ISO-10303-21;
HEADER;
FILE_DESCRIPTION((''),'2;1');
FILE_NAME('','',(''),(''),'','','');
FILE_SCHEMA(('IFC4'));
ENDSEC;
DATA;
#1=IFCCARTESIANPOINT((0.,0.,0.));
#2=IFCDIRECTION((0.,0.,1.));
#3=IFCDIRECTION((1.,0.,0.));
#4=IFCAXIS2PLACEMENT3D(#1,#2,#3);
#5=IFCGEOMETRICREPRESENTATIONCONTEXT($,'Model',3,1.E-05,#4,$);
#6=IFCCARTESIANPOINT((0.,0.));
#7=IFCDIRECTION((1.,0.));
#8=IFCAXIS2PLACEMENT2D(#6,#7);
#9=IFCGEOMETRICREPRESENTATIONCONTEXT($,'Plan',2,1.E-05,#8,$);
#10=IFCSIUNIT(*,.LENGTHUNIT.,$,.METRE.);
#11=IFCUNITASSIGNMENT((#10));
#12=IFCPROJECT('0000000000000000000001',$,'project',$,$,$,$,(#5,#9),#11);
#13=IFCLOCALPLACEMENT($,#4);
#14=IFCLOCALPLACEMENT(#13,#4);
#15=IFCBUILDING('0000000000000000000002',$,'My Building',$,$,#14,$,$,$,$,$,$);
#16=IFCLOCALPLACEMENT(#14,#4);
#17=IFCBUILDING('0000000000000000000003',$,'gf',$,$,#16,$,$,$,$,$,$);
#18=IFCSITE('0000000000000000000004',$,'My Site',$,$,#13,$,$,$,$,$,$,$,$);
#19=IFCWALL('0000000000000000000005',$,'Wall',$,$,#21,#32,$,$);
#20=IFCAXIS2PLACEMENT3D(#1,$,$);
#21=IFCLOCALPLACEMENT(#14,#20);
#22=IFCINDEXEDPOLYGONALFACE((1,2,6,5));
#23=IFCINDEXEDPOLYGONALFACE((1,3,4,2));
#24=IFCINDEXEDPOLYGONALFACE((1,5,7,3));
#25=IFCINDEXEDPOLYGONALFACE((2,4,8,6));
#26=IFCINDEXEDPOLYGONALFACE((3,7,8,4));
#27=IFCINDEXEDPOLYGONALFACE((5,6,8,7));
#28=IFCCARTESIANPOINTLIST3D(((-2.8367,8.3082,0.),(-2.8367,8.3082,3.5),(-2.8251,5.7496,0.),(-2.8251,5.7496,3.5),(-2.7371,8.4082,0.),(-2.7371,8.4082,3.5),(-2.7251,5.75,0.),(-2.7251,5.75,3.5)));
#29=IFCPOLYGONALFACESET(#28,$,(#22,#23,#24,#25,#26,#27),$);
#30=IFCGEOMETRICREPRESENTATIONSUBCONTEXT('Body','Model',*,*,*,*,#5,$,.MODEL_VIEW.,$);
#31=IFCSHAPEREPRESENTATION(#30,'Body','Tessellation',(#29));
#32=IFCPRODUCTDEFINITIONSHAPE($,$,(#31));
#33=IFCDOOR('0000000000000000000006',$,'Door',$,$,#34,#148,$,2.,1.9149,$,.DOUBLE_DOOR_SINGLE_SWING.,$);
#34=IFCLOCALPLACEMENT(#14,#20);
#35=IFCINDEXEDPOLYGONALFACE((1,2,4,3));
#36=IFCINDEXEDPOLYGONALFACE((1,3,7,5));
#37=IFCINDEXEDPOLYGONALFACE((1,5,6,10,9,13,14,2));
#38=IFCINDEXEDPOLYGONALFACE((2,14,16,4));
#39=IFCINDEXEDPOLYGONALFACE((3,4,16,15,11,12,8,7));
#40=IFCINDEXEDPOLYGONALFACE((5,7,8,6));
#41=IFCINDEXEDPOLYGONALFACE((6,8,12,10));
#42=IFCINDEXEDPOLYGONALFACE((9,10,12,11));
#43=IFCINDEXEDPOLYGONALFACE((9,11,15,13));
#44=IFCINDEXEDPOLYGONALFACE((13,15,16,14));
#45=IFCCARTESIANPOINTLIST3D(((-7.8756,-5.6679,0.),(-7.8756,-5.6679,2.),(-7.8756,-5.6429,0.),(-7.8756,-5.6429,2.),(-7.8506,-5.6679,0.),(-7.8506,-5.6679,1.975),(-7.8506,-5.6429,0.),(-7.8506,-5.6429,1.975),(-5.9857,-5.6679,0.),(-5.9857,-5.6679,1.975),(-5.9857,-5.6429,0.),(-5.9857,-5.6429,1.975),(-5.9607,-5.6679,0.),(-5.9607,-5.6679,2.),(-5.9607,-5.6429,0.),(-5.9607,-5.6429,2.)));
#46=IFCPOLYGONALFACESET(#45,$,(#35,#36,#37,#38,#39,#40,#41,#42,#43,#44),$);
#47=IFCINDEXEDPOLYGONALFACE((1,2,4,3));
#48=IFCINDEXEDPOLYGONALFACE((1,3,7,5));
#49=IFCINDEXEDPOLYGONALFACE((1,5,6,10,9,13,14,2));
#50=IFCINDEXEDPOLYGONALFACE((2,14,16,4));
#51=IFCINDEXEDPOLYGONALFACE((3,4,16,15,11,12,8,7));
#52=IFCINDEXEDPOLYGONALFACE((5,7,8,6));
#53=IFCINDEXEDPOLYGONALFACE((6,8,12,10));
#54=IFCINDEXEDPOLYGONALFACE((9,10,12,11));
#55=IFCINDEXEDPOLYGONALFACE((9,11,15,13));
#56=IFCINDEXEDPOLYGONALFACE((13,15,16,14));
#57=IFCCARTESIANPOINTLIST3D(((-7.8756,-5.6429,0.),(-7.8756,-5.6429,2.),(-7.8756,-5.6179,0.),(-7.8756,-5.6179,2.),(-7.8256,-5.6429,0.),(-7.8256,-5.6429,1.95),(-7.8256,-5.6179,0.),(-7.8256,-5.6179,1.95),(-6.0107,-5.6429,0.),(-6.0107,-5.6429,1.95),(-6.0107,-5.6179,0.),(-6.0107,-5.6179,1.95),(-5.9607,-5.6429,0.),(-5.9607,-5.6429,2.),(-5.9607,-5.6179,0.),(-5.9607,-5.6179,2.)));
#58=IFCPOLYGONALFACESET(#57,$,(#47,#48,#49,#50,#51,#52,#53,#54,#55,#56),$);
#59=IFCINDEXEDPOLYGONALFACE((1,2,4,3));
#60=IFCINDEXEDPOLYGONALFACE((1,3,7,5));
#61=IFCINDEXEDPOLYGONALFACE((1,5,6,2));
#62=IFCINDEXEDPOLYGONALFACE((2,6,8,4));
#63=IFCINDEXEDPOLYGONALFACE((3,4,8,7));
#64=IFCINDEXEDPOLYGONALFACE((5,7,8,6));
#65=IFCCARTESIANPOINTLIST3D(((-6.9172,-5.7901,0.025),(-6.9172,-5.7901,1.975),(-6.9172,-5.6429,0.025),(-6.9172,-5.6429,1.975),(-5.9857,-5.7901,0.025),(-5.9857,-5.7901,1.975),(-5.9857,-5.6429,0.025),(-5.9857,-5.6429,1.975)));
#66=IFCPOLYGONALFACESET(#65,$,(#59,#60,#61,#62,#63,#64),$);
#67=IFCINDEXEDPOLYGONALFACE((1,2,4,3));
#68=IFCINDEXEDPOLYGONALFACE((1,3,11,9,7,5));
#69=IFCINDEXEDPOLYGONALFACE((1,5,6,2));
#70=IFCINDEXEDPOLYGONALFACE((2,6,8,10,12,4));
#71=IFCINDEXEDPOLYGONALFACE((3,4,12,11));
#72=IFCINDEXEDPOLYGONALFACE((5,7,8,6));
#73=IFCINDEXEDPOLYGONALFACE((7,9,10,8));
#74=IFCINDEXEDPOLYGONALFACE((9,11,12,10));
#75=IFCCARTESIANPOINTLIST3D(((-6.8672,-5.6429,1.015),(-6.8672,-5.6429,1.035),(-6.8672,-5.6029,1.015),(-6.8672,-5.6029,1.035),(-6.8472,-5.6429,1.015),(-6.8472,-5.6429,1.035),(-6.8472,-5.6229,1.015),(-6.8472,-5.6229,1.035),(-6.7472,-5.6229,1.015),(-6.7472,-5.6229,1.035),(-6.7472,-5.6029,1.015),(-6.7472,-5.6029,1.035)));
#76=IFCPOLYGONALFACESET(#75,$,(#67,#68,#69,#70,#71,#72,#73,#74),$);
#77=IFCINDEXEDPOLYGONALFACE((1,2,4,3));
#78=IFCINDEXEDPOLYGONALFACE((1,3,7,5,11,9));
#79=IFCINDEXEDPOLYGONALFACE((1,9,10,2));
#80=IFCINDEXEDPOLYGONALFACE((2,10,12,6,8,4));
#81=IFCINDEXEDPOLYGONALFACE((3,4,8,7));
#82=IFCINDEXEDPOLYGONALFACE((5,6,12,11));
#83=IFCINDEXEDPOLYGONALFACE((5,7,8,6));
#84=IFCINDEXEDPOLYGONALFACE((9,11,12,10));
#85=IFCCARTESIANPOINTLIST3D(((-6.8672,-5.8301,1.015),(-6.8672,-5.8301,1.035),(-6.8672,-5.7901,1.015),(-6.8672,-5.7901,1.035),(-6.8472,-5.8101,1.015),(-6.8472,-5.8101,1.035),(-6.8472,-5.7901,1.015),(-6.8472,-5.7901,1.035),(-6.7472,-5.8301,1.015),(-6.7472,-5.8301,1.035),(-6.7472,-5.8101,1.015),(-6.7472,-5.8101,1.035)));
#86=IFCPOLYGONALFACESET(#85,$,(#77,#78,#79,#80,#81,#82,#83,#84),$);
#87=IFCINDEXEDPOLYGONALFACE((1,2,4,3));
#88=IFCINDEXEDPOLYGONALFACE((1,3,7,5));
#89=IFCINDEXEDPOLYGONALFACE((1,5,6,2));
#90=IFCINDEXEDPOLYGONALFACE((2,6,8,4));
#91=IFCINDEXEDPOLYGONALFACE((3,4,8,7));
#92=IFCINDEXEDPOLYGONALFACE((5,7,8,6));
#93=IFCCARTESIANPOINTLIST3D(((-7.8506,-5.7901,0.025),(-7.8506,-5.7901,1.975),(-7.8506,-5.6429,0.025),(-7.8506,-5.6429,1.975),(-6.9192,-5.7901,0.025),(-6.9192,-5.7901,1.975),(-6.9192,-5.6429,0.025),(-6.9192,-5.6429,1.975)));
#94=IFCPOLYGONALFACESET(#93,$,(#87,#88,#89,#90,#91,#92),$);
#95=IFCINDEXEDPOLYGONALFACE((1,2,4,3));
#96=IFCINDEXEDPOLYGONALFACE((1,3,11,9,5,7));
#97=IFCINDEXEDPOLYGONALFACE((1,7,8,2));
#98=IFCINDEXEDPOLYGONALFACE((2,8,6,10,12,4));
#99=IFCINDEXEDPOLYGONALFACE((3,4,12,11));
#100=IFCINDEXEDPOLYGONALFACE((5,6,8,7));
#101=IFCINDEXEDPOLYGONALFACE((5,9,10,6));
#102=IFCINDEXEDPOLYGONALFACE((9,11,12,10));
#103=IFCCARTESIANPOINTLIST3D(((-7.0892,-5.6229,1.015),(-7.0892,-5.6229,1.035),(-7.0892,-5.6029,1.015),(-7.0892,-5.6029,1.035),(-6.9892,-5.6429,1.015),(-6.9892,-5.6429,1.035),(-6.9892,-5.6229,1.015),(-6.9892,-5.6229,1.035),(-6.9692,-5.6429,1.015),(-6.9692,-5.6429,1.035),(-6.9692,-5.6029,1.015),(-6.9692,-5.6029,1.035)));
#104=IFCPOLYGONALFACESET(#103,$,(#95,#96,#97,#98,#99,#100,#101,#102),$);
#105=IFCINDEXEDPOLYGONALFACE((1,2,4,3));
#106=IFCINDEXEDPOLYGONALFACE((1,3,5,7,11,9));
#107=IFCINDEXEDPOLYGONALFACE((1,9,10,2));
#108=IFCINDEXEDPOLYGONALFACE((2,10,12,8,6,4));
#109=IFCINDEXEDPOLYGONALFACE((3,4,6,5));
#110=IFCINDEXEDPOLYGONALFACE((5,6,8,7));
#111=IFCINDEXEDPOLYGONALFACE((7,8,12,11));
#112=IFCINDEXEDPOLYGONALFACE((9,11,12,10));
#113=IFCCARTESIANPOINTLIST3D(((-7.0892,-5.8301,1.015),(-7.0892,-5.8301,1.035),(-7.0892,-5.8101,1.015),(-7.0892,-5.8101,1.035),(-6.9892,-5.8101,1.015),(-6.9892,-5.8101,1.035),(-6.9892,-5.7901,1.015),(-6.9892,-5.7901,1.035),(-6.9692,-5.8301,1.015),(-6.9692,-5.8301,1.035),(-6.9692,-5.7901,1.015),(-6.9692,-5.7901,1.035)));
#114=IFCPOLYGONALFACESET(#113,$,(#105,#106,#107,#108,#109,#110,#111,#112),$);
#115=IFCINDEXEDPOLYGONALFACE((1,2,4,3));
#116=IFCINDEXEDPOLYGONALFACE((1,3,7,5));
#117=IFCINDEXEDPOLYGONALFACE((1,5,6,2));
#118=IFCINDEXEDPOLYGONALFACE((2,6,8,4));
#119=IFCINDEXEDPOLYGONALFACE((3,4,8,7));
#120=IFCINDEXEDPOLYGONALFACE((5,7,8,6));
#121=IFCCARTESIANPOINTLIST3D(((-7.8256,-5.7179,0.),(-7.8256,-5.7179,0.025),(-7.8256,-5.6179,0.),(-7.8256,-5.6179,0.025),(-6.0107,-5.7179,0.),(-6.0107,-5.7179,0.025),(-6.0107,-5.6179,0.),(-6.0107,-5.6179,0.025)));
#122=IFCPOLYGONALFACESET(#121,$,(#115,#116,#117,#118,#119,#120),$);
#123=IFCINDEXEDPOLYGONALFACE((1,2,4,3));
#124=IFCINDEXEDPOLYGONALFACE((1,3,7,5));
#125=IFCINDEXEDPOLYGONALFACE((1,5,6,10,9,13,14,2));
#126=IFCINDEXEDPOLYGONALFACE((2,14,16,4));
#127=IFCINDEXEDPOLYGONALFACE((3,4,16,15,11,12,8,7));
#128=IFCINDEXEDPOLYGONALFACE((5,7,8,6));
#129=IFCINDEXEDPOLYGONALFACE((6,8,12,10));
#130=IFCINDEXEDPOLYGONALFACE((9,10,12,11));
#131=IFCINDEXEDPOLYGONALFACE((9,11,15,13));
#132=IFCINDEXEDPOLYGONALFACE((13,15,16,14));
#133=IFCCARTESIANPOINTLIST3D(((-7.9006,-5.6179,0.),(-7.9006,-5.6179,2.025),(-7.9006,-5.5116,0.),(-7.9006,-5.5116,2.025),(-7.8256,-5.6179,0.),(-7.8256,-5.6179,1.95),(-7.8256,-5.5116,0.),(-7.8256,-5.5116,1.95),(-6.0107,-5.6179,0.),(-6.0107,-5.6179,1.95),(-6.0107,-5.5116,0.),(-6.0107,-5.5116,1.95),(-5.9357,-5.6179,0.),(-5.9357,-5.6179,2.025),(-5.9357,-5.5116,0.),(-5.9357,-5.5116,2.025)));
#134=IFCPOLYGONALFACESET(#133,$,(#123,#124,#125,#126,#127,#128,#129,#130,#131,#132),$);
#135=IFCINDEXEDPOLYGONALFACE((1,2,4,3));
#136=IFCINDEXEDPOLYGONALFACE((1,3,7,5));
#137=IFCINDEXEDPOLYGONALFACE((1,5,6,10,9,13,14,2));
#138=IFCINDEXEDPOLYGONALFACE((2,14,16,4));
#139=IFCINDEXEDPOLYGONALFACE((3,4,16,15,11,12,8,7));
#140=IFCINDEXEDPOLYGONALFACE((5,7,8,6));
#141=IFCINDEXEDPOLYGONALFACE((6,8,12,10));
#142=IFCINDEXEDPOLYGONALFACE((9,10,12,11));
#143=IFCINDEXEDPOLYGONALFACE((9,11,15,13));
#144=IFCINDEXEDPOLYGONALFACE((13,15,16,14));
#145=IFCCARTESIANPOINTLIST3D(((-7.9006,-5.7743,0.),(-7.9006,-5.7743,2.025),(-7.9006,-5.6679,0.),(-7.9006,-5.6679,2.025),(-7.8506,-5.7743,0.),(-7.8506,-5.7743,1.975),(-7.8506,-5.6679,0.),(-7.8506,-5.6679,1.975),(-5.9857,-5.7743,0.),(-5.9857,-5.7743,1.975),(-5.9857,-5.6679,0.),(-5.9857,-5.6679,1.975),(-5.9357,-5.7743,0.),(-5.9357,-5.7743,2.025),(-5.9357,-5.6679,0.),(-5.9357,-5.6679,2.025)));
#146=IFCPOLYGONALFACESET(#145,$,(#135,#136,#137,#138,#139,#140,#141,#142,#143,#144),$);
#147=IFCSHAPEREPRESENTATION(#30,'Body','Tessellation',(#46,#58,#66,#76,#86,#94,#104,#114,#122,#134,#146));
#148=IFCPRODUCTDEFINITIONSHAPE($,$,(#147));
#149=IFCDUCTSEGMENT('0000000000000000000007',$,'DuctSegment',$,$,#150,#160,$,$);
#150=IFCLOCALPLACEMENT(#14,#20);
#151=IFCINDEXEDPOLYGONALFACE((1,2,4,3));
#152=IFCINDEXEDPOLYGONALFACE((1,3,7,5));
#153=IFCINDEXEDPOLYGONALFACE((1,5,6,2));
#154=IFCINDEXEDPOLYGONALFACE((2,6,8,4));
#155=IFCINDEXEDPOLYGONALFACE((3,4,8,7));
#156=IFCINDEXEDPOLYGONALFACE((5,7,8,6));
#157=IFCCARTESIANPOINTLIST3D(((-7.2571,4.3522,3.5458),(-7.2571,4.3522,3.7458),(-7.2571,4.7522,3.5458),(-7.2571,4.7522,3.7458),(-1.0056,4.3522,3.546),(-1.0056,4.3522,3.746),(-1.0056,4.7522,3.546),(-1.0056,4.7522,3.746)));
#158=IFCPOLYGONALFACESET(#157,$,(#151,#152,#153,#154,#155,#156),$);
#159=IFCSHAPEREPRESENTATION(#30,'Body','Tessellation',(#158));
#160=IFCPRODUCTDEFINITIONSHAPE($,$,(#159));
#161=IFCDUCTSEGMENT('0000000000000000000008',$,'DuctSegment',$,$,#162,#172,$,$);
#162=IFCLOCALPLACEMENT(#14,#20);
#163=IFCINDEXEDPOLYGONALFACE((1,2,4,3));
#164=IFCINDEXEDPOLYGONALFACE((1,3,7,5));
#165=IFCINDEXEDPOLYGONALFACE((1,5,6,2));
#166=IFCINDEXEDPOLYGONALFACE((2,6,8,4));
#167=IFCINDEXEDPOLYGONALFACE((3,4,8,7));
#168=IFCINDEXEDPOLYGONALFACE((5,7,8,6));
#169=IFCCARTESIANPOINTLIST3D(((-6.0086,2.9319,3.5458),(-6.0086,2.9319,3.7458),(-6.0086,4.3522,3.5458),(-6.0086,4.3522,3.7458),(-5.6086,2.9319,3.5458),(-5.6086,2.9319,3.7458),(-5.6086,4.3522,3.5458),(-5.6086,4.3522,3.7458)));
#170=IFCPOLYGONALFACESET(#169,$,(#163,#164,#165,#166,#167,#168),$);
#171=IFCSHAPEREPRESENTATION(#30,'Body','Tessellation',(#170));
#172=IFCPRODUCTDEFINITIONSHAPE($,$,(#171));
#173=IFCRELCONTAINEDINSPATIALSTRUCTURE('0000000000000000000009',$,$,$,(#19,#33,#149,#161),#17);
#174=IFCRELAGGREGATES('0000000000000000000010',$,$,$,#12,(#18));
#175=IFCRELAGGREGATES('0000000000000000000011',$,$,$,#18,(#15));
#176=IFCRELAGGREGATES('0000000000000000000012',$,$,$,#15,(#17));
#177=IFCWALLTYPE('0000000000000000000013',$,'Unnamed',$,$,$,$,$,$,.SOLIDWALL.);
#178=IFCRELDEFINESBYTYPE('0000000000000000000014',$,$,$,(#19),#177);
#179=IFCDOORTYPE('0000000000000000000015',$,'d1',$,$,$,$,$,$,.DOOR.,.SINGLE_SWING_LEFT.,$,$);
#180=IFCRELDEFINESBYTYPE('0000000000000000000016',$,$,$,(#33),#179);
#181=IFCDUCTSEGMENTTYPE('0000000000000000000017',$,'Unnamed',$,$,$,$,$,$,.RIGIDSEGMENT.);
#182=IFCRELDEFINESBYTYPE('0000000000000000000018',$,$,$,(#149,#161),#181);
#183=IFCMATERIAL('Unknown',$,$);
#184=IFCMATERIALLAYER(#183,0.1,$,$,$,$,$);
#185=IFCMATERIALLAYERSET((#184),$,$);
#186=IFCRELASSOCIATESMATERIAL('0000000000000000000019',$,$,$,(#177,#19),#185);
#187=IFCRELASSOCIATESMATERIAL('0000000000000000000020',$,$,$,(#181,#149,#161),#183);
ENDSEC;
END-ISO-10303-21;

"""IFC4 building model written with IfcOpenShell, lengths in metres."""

from ifc_helpers import new_model, entity, si_unit, frame, origin_with_axes, origin_2d_with_axis, place, context, subcontext, project, spatial, line, indexed_curve, rectangle, outline, extrude, shape, source, transform, mapped, material, layer, layer_set, layer_usage, material_profile, profile_set, profile_usage, type_object, type_shapes, element, save


model = new_model("IFC4")

# Units and contexts
model_context = context("Model", 3, precision=1e-05, world=origin_with_axes())
plan_context = context("Plan", 2, precision=1e-05, world=origin_2d_with_axis())
body_context_1 = subcontext(model_context, "Body", "Model", "MODEL_VIEW")
body_context_2 = subcontext(plan_context, "Body", "Plan", "PLAN_VIEW")
ifc_project = project(units=[si_unit("LENGTHUNIT", "METRE")], contexts=[model_context, plan_context])

# Site, buildings
site_placement = place(None, origin_with_axes())
site = spatial("IfcSite", under=ifc_project, at=site_placement, Name="My Site")
building_1_placement = place(site_placement, origin_with_axes())
building_1 = spatial("IfcBuilding", under=site, at=building_1_placement, Name="My Building")
building_2_placement = place(building_1_placement, origin_with_axes())
building_2 = spatial("IfcBuilding", under=building_1, at=building_2_placement, Name="gf")

# Shared definitions
ifc_material = material(Name="Unknown")

# Shared definitions
ifc_layer_1 = layer(ifc_material, 0.1)
ifc_layer_set_1 = layer_set([ifc_layer_1])
wall_type = type_object("IfcWallType", Name="Unnamed", PredefinedType="SOLIDWALL", material=ifc_layer_set_1)

# Shared definitions
door_type = type_object("IfcDoorType", Name="d1", OperationType="SINGLE_SWING_LEFT", PredefinedType="DOOR")
shared_shape_1 = source(origin_with_axes(), body_context_1, "Body", "SweptSolid", [
    extrude(outline(indexed_curve([(0.0, 0.0), (0.0, 2.0), (1.9149, 2.0), (1.9149, 0.0), (1.8899, 0.0), (1.8899, 1.975), (0.025, 1.975), (0.025, 0.0)], segments=[line(1, 2, 3, 4, 5, 6, 7, 8, 1)])), frame((0.0, 0.025, 0.0), z_axis=(0.0, -1.0, 0.0), x_axis=(1.0, 0.0, 0.0)), (0.0, 0.0, -1.0), 0.025),
    extrude(outline(indexed_curve([(0.0, 0.0), (0.0, 2.0), (1.9149, 2.0), (1.9149, 0.0), (1.8649, 0.0), (1.8649, 1.95), (0.05, 1.95), (0.05, 0.0)], segments=[line(1, 2, 3, 4, 5, 6, 7, 8, 1)])), frame((0.0, 0.0, 0.0), z_axis=(0.0, -1.0, 0.0), x_axis=(1.0, 0.0, 0.0)), (0.0, 0.0, -1.0), 0.025),
    extrude(outline(indexed_curve([(0.0, 0.0), (0.9315, 0.0), (0.9315, 0.1472), (0.0, 0.1472)], segments=[line(1, 2, 3, 4, 1)])), frame((0.025, 0.025, 0.025), z_axis=(0.0, 0.0, 1.0), x_axis=(1.0, 0.0, 0.0)), (0.0, 0.0, 1.0), 1.95),
    extrude(outline(indexed_curve([(0.0, 0.0), (0.0, -0.04), (-0.12, -0.04), (-0.12, -0.02), (-0.02, -0.02), (-0.02, 0.0)], segments=[line(1, 2, 3, 4, 5, 6, 1)])), frame((0.9065, 0.025, 1.015), z_axis=(0.0, 0.0, 1.0), x_axis=(1.0, 0.0, 0.0)), (0.0, 0.0, 1.0), 0.02),
    extrude(outline(indexed_curve([(0.0, 0.0), (0.0, 0.04), (-0.12, 0.04), (-0.12, 0.02), (-0.02, 0.02), (-0.02, 0.0)], segments=[line(1, 2, 3, 4, 5, 6, 1)])), frame((0.9065, 0.1722, 1.015), z_axis=(0.0, 0.0, 1.0), x_axis=(1.0, 0.0, 0.0)), (0.0, 0.0, 1.0), 0.02),
    extrude(outline(indexed_curve([(0.0, 0.0), (-0.9315, 0.0), (-0.9315, 0.1472), (0.0, 0.1472)], segments=[line(1, 2, 3, 4, 1)])), frame((1.8899, 0.025, 0.025), z_axis=(0.0, 0.0, 1.0), x_axis=(1.0, 0.0, 0.0)), (0.0, 0.0, 1.0), 1.95),
    extrude(outline(indexed_curve([(0.0, 0.0), (0.0, -0.04), (0.12, -0.04), (0.12, -0.02), (0.02, -0.02), (0.02, 0.0)], segments=[line(1, 2, 3, 4, 5, 6, 1)])), frame((1.0085, 0.025, 1.015), z_axis=(0.0, 0.0, 1.0), x_axis=(1.0, 0.0, 0.0)), (0.0, 0.0, 1.0), 0.02),
    extrude(outline(indexed_curve([(0.0, 0.0), (0.0, 0.04), (0.12, 0.04), (0.12, 0.02), (0.02, 0.02), (0.02, 0.0)], segments=[line(1, 2, 3, 4, 5, 6, 1)])), frame((1.0085, 0.1722, 1.015), z_axis=(0.0, 0.0, 1.0), x_axis=(1.0, 0.0, 0.0)), (0.0, 0.0, 1.0), 0.02),
    extrude(outline(indexed_curve([(0.0, 0.0), (1.8149, 0.0), (1.8149, 0.1), (0.0, 0.1)], segments=[line(1, 2, 3, 4, 1)])), frame((0.05, 0.0, 0.0), z_axis=(0.0, 0.0, 1.0), x_axis=(1.0, 0.0, 0.0)), (0.0, 0.0, 1.0), 0.025),
    extrude(outline(indexed_curve([(0.0, 0.0), (0.0, 2.025), (1.9649, 2.025), (1.9649, 0.0), (1.8899, 0.0), (1.8899, 1.95), (0.075, 1.95), (0.075, 0.0)], segments=[line(1, 2, 3, 4, 5, 6, 7, 8, 1)])), frame((-0.025, -0.1064, 0.0), z_axis=(0.0, -1.0, 0.0), x_axis=(1.0, 0.0, 0.0)), (0.0, 0.0, -1.0), 0.1064),
    extrude(outline(indexed_curve([(0.0, 0.0), (0.0, 2.025), (1.9649, 2.025), (1.9649, 0.0), (1.9149, 0.0), (1.9149, 1.975), (0.05, 1.975), (0.05, 0.0)], segments=[line(1, 2, 3, 4, 5, 6, 7, 8, 1)])), frame((-0.025, 0.05, 0.0), z_axis=(0.0, -1.0, 0.0), x_axis=(1.0, 0.0, 0.0)), (0.0, 0.0, -1.0), 0.1064),
])
shared_shape_2 = source(origin_with_axes(), body_context_2, "Body", "Curve2D", [
    entity("IfcIndexedPolyCurve", entity("IfcCartesianPointList2D", [[0.0, 0.0], [0.0, 0.05], [0.025, 0.05], [0.025, 0.025], [0.05, 0.025], [0.05, 0.0]]), [entity("IfcLineIndex", [1, 2, 3, 4, 5, 6, 1])]),
    entity("IfcIndexedPolyCurve", entity("IfcCartesianPointList2D", [[1.9149, 0.0], [1.9149, 0.05], [1.8899, 0.05], [1.8899, 0.025], [1.8649, 0.025], [1.8649, 0.0]]), [entity("IfcLineIndex", [1, 2, 3, 4, 5, 6, 1])]),
    entity("IfcTrimmedCurve", entity("IfcEllipse", entity("IfcAxis2Placement2D", entity("IfcCartesianPoint", [0.1722, 0.05]), entity("IfcDirection", [1.0, 0.0])), 0.7853, 0.9325), [entity("IfcCartesianPoint", [0.9575, 0.05])], [entity("IfcCartesianPoint", [0.1722, 0.9825])], True, "CARTESIAN"),
    entity("IfcIndexedPolyCurve", entity("IfcCartesianPointList2D", [[0.025, 0.05], [0.1722, 0.05], [0.1722, 0.9825], [0.025, 0.9825]]), [entity("IfcLineIndex", [1, 2, 3, 4, 1])]),
    entity("IfcTrimmedCurve", entity("IfcEllipse", entity("IfcAxis2Placement2D", entity("IfcCartesianPoint", [1.7427, 0.05]), entity("IfcDirection", [1.0, 0.0])), 0.7853, 0.9325), [entity("IfcCartesianPoint", [1.7427, 0.9825])], [entity("IfcCartesianPoint", [0.9575, 0.05])], True, "CARTESIAN"),
    entity("IfcIndexedPolyCurve", entity("IfcCartesianPointList2D", [[1.8899, 0.05], [1.7427, 0.05], [1.7427, 0.9825], [1.8899, 0.9825]]), [entity("IfcLineIndex", [1, 2, 3, 4, 1])]),
])
type_shapes(door_type, [shared_shape_1, shared_shape_2])

# Wall
ifc_layer_usage_1 = layer_usage(ifc_layer_set_1, "AXIS2", "POSITIVE", 0.0)
wall_1_placement = place(building_2_placement, frame((-2.8367, 8.3082, 0.0), z_axis=(0.0, 0.0, 1.0), x_axis=(0.00454, -0.99999, 0.0)))
element("IfcWall", 1, at=wall_1_placement, inside=building_2, type_object=wall_type, material=ifc_layer_usage_1, Name="Wall", context=body_context_1, shape_type="SweptSolid", body=[
    extrude(outline(indexed_curve([(0.0, 0.0), (-0.0995, 0.1), (2.5586, 0.1), (2.5586, 0.0)], segments=[line(1, 2, 3, 4, 1)])), origin_with_axes(), (0.0, 0.0, 1.0), 3.5),
])

# Door
door_1_placement = place(building_2_placement, frame((-5.9607, -5.6179, 0.0), z_axis=(0.0, 0.0, 1.0), x_axis=(-1.0, 0.0, 0.0)))
element("IfcDoor", 2, at=door_1_placement, inside=building_2, type_object=door_type, Name="Door", OperationType="DOUBLE_DOOR_SINGLE_SWING", OverallHeight=2.0, OverallWidth=1.9149, shapes=[
    shape(body_context_1, "Body", "MappedRepresentation", [mapped(shared_shape_1, transform((0.0, 0.0, 0.0), x_axis=(1.0, 0.0, 0.0), y_axis=(0.0, 1.0, 0.0), z_axis=(0.0, 0.0, 1.0), scale=1.0))]),
    shape(body_context_2, "Body", "MappedRepresentation", [mapped(shared_shape_2, transform((0.0, 0.0, 0.0), x_axis=(1.0, 0.0, 0.0), y_axis=(0.0, 1.0, 0.0), z_axis=(0.0, 0.0, 1.0), scale=1.0))]),
])

# Duct segments
ifc_material_profile_1 = material_profile(ifc_material, rectangle(XDim=0.4, YDim=0.2))
ifc_profile_set_1 = profile_set([ifc_material_profile_1])
ifc_profile_usage_1 = profile_usage(ifc_profile_set_1, cardinal=5)
duct_segment_type = type_object("IfcDuctSegmentType", Name="Unnamed", PredefinedType="RIGIDSEGMENT", material=ifc_profile_set_1)
duct_segment_1_placement = place(building_2_placement, frame((-7.2571, 4.5522, 3.6458), z_axis=(1.0, 0.0, 0.000029), x_axis=(0.0, 1.0, 0.0)))
element("IfcDuctSegment", 3, at=duct_segment_1_placement, inside=building_2, type_object=duct_segment_type, material=ifc_profile_usage_1, Name="DuctSegment", context=body_context_1, shape_type="SweptSolid", body=[
    extrude(rectangle(XDim=0.4, YDim=0.2), origin_with_axes(), (0.0, 0.0, 1.0), 6.2515),
])
ifc_profile_usage_2 = profile_usage(ifc_profile_set_1, cardinal=5)
duct_segment_2_placement = place(building_2_placement, frame((-5.8086, 2.9319, 3.6458), z_axis=(0.0, 1.0, 0.0), x_axis=(-1.0, 0.0, 0.0)))
element("IfcDuctSegment", 4, at=duct_segment_2_placement, inside=building_2, type_object=duct_segment_type, material=ifc_profile_usage_2, Name="DuctSegment", context=body_context_1, shape_type="SweptSolid", body=[
    extrude(rectangle(XDim=0.4, YDim=0.2), origin_with_axes(), (0.0, 0.0, 1.0), 1.4203),
])

save(model, "model.ifc")
